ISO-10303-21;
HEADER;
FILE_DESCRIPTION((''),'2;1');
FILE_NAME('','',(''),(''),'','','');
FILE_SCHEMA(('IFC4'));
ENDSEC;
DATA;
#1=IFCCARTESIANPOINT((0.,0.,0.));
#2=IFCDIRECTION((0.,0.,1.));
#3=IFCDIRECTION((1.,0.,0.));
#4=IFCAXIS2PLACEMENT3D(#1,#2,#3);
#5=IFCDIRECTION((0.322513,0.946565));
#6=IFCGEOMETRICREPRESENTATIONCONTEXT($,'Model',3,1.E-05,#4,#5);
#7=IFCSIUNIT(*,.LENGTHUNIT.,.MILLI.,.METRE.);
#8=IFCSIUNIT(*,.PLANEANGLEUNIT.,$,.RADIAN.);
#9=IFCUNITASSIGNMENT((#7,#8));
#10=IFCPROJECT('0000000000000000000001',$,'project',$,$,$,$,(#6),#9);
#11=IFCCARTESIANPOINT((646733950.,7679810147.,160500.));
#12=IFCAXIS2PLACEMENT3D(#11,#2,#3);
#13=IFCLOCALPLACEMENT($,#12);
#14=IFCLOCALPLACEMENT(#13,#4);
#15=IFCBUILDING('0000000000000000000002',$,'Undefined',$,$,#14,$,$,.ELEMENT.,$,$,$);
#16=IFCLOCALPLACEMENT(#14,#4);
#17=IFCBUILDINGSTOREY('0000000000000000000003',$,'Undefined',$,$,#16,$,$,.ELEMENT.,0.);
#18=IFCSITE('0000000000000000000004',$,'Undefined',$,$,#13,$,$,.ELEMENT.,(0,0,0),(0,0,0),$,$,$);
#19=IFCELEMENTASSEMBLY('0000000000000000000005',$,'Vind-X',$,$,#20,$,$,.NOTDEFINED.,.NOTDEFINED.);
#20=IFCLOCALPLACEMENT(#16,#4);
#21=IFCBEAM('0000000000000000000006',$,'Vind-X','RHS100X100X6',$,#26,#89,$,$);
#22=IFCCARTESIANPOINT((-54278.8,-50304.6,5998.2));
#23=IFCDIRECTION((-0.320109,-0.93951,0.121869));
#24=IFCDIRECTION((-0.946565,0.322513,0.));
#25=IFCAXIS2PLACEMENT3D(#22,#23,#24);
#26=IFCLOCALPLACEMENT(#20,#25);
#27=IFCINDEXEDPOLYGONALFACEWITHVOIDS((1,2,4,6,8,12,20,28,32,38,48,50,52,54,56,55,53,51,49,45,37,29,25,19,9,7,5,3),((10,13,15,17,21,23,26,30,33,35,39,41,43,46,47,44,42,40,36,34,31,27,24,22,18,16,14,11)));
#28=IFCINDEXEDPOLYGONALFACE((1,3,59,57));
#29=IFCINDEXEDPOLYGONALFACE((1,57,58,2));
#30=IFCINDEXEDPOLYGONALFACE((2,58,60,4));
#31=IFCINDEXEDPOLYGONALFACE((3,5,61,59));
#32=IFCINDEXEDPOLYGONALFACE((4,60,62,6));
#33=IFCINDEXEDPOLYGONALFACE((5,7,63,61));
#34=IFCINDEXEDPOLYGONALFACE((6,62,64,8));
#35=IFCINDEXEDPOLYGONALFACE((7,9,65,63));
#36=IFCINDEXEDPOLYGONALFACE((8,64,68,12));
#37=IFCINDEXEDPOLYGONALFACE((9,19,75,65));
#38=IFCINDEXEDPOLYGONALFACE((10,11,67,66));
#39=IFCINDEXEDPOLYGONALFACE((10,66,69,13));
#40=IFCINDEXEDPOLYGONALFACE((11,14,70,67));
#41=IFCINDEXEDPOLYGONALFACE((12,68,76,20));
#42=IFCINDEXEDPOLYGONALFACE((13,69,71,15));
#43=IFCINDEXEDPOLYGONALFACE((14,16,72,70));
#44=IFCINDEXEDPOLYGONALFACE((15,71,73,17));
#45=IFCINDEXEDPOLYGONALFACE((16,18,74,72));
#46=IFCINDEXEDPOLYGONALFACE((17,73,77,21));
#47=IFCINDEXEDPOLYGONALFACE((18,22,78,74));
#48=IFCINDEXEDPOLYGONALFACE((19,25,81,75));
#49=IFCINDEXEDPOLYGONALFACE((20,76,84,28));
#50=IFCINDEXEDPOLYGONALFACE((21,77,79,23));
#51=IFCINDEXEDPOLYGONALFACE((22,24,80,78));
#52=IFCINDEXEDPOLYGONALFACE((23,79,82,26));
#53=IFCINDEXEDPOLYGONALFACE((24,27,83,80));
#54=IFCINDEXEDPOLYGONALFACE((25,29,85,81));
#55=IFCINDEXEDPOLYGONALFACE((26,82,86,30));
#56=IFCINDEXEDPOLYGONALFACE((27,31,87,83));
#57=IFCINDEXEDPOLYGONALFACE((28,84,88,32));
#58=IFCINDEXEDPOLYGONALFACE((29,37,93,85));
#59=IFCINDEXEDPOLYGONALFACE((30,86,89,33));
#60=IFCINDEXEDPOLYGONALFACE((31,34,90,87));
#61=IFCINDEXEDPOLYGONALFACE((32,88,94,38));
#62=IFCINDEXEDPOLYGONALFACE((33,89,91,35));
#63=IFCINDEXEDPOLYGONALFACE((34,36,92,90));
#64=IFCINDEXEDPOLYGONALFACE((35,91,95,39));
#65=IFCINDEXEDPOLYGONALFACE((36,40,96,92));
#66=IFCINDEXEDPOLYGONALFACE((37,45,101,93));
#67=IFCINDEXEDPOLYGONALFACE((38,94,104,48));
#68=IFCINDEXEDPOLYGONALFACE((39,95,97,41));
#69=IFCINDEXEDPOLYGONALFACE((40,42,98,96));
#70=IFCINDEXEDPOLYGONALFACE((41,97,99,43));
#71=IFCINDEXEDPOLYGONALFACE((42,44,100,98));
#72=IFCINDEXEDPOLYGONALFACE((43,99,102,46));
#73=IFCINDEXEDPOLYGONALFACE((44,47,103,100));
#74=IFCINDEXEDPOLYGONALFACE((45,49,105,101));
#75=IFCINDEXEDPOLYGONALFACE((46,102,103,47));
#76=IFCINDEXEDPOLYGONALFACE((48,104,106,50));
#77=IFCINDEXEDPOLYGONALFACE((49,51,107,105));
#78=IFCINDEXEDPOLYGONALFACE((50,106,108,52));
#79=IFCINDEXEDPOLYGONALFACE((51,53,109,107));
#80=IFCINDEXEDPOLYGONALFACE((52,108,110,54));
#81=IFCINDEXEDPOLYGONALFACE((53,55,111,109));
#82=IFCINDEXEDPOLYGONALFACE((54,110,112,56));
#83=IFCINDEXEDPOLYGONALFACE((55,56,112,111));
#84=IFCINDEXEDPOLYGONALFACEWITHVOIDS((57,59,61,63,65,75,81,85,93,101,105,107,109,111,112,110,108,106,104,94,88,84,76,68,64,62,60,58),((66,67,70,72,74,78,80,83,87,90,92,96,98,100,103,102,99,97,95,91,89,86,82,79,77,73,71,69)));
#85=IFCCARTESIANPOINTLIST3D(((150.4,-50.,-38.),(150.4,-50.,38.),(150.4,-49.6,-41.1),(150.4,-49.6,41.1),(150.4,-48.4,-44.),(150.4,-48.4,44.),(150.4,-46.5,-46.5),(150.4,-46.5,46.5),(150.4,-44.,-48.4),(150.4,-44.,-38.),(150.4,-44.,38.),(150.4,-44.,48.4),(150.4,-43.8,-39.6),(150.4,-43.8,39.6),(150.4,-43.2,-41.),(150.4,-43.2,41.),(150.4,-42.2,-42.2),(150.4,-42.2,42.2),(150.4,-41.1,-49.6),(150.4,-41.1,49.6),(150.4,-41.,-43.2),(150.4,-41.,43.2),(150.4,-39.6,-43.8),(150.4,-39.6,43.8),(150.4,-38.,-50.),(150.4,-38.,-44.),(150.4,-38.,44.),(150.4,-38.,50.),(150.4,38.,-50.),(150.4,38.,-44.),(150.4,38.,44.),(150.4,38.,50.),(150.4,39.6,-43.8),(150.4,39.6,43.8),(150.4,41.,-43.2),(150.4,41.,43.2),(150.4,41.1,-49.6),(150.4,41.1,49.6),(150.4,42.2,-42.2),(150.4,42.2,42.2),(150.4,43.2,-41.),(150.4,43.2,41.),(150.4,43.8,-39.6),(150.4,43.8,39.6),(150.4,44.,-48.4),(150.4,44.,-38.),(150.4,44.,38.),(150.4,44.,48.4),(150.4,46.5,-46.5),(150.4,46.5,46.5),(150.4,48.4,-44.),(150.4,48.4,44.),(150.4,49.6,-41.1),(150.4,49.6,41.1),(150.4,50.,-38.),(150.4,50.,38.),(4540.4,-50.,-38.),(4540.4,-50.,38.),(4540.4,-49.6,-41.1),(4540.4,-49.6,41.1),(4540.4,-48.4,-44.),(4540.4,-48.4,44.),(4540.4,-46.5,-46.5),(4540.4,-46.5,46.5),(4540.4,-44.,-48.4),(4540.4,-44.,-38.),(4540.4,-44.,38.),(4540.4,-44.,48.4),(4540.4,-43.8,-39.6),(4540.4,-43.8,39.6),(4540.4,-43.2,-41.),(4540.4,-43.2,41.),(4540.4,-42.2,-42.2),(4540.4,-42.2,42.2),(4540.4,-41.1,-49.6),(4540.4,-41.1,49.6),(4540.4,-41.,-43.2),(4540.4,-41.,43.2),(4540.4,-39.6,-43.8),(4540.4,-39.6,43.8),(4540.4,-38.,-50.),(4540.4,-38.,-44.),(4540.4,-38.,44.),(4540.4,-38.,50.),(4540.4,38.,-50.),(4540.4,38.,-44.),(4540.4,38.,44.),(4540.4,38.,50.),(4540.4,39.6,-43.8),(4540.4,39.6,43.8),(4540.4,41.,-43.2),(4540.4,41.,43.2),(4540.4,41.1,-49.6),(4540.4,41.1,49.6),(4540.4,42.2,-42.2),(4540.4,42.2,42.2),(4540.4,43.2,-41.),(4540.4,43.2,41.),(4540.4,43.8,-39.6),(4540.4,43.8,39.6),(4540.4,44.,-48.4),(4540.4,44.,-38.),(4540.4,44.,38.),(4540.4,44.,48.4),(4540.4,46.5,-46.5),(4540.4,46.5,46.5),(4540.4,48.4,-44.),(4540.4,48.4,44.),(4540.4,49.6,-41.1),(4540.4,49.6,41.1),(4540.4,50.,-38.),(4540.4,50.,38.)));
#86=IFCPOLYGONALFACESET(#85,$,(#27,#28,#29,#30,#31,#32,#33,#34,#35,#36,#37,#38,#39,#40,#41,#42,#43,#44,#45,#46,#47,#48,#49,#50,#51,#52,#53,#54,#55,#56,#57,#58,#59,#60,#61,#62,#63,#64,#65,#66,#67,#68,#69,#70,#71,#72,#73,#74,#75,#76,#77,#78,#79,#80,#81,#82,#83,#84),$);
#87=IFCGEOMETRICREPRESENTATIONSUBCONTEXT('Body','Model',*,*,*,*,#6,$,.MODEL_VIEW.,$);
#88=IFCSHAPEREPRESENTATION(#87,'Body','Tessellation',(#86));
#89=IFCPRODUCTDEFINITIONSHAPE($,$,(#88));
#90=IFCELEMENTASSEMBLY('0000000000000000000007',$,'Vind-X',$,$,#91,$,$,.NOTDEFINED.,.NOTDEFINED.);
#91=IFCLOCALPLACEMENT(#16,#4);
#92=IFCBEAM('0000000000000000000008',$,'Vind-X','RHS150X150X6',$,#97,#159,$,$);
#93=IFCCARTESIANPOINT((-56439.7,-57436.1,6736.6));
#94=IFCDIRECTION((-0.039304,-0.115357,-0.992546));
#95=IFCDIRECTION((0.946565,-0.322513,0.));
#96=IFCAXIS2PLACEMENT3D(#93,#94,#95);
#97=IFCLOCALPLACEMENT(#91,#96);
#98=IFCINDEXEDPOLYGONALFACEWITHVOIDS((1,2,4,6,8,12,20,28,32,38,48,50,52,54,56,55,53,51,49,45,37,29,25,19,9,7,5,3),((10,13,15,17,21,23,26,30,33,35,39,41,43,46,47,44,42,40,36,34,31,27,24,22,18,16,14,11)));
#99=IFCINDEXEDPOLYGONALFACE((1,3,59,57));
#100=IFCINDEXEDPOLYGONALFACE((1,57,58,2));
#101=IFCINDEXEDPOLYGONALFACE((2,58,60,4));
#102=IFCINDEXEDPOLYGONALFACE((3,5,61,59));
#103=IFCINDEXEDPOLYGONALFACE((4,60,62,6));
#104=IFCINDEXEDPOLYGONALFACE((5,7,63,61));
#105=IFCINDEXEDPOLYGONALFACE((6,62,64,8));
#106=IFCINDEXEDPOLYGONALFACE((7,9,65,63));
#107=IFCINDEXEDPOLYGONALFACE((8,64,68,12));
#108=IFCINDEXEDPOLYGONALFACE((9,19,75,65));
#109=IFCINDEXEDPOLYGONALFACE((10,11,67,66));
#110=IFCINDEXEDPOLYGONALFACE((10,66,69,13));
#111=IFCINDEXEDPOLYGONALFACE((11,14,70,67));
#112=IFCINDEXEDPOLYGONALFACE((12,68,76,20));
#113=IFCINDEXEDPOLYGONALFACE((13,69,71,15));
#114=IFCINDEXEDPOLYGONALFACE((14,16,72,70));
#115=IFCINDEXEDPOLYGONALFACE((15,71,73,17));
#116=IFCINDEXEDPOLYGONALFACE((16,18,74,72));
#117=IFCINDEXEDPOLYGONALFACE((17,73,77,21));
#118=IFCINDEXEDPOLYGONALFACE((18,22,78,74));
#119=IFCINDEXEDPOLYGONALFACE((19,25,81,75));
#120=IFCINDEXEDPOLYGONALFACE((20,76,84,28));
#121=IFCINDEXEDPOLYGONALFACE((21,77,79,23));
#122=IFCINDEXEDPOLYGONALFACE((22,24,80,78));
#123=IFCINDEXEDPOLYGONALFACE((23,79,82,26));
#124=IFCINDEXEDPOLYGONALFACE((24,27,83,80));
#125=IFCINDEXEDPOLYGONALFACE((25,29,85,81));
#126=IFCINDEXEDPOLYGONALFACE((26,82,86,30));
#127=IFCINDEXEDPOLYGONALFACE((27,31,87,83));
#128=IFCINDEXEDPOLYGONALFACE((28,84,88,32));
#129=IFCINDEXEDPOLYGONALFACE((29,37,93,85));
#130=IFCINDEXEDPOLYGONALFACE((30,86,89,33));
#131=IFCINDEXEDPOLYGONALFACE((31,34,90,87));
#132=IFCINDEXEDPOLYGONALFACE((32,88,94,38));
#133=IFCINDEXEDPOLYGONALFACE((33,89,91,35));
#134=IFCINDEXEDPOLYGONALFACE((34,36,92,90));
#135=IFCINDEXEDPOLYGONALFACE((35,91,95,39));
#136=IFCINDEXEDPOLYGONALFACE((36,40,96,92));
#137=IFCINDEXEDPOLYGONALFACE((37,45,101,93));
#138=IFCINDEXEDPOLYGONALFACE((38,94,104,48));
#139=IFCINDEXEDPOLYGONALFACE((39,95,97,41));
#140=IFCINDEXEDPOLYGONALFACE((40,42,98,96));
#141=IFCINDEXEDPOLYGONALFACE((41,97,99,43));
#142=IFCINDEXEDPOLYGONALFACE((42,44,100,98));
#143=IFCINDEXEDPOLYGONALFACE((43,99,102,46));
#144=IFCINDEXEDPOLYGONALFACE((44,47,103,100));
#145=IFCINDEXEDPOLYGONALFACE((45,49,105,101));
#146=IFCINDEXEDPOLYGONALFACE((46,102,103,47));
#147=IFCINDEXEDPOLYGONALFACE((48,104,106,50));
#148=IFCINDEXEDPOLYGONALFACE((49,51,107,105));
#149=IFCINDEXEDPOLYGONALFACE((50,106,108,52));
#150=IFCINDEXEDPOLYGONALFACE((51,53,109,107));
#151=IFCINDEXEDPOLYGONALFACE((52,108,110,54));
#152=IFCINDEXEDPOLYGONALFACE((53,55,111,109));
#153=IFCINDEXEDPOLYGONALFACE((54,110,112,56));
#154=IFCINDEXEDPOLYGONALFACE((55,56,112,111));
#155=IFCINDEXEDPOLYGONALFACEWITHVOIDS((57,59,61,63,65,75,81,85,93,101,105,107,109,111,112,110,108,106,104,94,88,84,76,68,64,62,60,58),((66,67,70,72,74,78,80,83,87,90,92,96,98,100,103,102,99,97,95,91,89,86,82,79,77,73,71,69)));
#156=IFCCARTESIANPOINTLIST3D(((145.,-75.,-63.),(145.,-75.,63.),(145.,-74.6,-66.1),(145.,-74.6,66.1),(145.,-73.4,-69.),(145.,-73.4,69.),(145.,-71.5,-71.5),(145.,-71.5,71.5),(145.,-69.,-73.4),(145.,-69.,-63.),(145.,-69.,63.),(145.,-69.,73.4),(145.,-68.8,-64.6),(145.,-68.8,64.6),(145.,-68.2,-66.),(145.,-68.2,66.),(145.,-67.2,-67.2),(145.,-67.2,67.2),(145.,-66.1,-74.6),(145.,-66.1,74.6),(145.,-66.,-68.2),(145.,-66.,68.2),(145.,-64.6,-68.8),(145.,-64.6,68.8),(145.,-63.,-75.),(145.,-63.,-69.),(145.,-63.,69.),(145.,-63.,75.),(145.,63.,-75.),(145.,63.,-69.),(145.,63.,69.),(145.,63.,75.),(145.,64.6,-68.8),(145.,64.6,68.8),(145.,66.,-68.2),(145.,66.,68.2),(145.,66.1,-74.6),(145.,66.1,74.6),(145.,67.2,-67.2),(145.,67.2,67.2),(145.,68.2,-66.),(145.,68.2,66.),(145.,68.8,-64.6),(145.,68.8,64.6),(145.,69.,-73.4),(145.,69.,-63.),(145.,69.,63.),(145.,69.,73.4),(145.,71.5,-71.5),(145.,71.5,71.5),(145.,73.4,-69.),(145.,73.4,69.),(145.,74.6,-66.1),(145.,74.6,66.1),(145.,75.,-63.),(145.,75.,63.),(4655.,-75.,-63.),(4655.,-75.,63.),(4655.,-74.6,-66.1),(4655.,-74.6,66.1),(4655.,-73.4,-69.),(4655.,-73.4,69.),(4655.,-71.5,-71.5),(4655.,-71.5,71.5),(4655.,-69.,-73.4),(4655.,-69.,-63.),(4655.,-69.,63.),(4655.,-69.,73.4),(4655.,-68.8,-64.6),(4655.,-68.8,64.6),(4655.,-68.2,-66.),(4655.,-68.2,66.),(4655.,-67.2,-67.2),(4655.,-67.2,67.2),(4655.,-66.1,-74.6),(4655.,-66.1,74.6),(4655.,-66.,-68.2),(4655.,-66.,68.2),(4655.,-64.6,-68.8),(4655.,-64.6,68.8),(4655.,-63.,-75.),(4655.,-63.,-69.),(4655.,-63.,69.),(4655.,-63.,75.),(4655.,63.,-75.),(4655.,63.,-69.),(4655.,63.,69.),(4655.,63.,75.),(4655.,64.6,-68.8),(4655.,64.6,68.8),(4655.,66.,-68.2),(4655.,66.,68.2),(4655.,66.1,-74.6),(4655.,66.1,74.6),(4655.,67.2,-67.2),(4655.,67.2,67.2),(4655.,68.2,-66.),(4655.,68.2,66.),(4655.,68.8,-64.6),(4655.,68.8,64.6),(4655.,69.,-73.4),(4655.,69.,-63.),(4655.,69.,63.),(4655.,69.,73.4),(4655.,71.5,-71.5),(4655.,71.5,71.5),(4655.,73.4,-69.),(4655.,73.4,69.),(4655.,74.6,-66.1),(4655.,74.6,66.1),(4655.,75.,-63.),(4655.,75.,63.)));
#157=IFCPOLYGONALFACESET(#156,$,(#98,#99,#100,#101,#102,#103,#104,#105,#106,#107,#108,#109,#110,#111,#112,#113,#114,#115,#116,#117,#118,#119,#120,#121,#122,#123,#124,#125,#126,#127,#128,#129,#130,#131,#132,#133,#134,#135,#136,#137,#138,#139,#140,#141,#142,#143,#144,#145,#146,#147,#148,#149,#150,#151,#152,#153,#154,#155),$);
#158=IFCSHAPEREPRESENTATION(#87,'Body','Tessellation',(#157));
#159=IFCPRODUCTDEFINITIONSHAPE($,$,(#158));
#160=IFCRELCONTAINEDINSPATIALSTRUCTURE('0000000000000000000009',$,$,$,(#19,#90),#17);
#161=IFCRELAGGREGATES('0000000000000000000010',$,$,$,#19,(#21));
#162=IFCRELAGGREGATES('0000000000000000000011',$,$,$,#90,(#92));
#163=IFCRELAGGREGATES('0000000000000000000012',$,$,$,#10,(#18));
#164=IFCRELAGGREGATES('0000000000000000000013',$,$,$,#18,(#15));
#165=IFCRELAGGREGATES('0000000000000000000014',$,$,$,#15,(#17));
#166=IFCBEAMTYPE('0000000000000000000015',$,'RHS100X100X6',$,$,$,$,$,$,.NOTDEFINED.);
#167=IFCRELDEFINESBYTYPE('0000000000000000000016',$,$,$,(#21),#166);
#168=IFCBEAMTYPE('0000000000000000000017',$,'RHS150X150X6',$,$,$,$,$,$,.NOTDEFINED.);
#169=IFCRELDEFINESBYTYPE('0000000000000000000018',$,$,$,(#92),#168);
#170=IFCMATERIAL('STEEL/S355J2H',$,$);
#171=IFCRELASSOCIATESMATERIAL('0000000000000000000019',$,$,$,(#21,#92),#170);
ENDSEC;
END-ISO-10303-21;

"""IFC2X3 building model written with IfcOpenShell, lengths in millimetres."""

from ifc_helpers import new_model, si_unit, direction, frame, origin_with_axes, origin_2d_with_axis, place, context, subcontext, project, spatial, hollow_rectangle, extrude, clip, halfspace, material, type_object, element, aggregate, save


model = new_model("IFC2X3")

# Units and contexts
model_context = context("Model", 3, precision=1e-05, world=origin_with_axes(), true_north=direction((0.322513, 0.946565)))
body_context = subcontext(model_context, "Body", "Model", "MODEL_VIEW")
ifc_project = project(units=[si_unit("LENGTHUNIT", "METRE", prefix="MILLI"), si_unit("PLANEANGLEUNIT", "RADIAN")], contexts=[model_context])

# Site, building, storey
site_placement = place(None, frame((646733950.0, 7679810147.0, 160500.0), z_axis=(0.0, 0.0, 1.0), x_axis=(1.0, 0.0, 0.0)))
site = spatial("IfcSite", under=ifc_project, at=site_placement, Name="Undefined", CompositionType="ELEMENT", RefLatitude=(0, 0, 0), RefLongitude=(0, 0, 0))
building_placement = place(site_placement, origin_with_axes())
building = spatial("IfcBuilding", under=site, at=building_placement, Name="Undefined", CompositionType="ELEMENT")
storey_placement = place(building_placement, origin_with_axes())
storey = spatial("IfcBuildingStorey", under=building, at=storey_placement, Name="Undefined", CompositionType="ELEMENT", Elevation=0.0)

# Element assemblies, beams
assembly_1_placement = place(storey_placement, origin_with_axes())
assembly_1 = element("IfcElementAssembly", 1, at=assembly_1_placement, inside=storey, Name="Vind-X", AssemblyPlace="NOTDEFINED", PredefinedType="NOTDEFINED")
ifc_material_1 = material(Name="STEEL/S355J2H")
beam_type_1 = type_object("IfcBeamType", Name="RHS100X100X6", PredefinedType="NOTDEFINED")
beam_1_placement = place(assembly_1_placement, frame((-54278.8, -50304.6, 5998.2), z_axis=(-0.320109, -0.93951, 0.121869), x_axis=(-0.946565, 0.322513, 0.0)))
beam_1 = element("IfcBeam", 2, at=beam_1_placement, type_object=beam_type_1, material=ifc_material_1, Name="Vind-X", Description="RHS100X100X6", context=body_context, shape_type="Clipping", body=[
    clip(clip(extrude(hollow_rectangle(XDim=100.0, YDim=100.0, WallThickness=6.0, InnerFilletRadius=6.0, OuterFilletRadius=12.0, at=origin_2d_with_axis()), frame((4690.0, 0.0, 0.0), z_axis=(-1.0, 0.0, 0.0), x_axis=(0.0, -1.0, 0.0)), (0.0, 0.0, 1.0), 4690.0), halfspace(frame((4540.4, 22.5, 0.0), z_axis=(-1.0, 0.0, 0.0), x_axis=(0.0, -1.0, 0.0)), True)), halfspace(frame((150.4, 22.5, 0.0), z_axis=(1.0, 0.0, 0.0), x_axis=(0.0, 0.0, -1.0)), True)),
])
assembly_2_placement = place(storey_placement, origin_with_axes())
assembly_2 = element("IfcElementAssembly", 3, at=assembly_2_placement, inside=storey, Name="Vind-X", AssemblyPlace="NOTDEFINED", PredefinedType="NOTDEFINED")
beam_type_2 = type_object("IfcBeamType", Name="RHS150X150X6", PredefinedType="NOTDEFINED")
beam_2_placement = place(assembly_2_placement, frame((-56439.7, -57436.1, 6736.6), z_axis=(-0.039304, -0.115357, -0.992546), x_axis=(0.946565, -0.322513, 0.0)))
beam_2 = element("IfcBeam", 4, at=beam_2_placement, type_object=beam_type_2, material=ifc_material_1, Name="Vind-X", Description="RHS150X150X6", context=body_context, shape_type="Clipping", body=[
    clip(clip(extrude(hollow_rectangle(XDim=150.0, YDim=150.0, WallThickness=6.0, InnerFilletRadius=6.0, OuterFilletRadius=12.0, at=origin_2d_with_axis()), frame((4800.0, 0.0, 0.0), z_axis=(-1.0, 0.0, 0.0), x_axis=(0.0, -1.0, 0.0)), (0.0, 0.0, 1.0), 4800.0), halfspace(frame((4655.0, 0.0, 0.0), z_axis=(-1.0, 0.0, 0.0), x_axis=(0.0, 1.0, 0.0)), True)), halfspace(frame((145.0, 0.0, 0.0), z_axis=(1.0, 0.0, 0.0), x_axis=(0.0, -1.0, 0.0)), True)),
])

aggregate(assembly_1, [beam_1])

aggregate(assembly_2, [beam_2])

save(model, "model.ifc")
